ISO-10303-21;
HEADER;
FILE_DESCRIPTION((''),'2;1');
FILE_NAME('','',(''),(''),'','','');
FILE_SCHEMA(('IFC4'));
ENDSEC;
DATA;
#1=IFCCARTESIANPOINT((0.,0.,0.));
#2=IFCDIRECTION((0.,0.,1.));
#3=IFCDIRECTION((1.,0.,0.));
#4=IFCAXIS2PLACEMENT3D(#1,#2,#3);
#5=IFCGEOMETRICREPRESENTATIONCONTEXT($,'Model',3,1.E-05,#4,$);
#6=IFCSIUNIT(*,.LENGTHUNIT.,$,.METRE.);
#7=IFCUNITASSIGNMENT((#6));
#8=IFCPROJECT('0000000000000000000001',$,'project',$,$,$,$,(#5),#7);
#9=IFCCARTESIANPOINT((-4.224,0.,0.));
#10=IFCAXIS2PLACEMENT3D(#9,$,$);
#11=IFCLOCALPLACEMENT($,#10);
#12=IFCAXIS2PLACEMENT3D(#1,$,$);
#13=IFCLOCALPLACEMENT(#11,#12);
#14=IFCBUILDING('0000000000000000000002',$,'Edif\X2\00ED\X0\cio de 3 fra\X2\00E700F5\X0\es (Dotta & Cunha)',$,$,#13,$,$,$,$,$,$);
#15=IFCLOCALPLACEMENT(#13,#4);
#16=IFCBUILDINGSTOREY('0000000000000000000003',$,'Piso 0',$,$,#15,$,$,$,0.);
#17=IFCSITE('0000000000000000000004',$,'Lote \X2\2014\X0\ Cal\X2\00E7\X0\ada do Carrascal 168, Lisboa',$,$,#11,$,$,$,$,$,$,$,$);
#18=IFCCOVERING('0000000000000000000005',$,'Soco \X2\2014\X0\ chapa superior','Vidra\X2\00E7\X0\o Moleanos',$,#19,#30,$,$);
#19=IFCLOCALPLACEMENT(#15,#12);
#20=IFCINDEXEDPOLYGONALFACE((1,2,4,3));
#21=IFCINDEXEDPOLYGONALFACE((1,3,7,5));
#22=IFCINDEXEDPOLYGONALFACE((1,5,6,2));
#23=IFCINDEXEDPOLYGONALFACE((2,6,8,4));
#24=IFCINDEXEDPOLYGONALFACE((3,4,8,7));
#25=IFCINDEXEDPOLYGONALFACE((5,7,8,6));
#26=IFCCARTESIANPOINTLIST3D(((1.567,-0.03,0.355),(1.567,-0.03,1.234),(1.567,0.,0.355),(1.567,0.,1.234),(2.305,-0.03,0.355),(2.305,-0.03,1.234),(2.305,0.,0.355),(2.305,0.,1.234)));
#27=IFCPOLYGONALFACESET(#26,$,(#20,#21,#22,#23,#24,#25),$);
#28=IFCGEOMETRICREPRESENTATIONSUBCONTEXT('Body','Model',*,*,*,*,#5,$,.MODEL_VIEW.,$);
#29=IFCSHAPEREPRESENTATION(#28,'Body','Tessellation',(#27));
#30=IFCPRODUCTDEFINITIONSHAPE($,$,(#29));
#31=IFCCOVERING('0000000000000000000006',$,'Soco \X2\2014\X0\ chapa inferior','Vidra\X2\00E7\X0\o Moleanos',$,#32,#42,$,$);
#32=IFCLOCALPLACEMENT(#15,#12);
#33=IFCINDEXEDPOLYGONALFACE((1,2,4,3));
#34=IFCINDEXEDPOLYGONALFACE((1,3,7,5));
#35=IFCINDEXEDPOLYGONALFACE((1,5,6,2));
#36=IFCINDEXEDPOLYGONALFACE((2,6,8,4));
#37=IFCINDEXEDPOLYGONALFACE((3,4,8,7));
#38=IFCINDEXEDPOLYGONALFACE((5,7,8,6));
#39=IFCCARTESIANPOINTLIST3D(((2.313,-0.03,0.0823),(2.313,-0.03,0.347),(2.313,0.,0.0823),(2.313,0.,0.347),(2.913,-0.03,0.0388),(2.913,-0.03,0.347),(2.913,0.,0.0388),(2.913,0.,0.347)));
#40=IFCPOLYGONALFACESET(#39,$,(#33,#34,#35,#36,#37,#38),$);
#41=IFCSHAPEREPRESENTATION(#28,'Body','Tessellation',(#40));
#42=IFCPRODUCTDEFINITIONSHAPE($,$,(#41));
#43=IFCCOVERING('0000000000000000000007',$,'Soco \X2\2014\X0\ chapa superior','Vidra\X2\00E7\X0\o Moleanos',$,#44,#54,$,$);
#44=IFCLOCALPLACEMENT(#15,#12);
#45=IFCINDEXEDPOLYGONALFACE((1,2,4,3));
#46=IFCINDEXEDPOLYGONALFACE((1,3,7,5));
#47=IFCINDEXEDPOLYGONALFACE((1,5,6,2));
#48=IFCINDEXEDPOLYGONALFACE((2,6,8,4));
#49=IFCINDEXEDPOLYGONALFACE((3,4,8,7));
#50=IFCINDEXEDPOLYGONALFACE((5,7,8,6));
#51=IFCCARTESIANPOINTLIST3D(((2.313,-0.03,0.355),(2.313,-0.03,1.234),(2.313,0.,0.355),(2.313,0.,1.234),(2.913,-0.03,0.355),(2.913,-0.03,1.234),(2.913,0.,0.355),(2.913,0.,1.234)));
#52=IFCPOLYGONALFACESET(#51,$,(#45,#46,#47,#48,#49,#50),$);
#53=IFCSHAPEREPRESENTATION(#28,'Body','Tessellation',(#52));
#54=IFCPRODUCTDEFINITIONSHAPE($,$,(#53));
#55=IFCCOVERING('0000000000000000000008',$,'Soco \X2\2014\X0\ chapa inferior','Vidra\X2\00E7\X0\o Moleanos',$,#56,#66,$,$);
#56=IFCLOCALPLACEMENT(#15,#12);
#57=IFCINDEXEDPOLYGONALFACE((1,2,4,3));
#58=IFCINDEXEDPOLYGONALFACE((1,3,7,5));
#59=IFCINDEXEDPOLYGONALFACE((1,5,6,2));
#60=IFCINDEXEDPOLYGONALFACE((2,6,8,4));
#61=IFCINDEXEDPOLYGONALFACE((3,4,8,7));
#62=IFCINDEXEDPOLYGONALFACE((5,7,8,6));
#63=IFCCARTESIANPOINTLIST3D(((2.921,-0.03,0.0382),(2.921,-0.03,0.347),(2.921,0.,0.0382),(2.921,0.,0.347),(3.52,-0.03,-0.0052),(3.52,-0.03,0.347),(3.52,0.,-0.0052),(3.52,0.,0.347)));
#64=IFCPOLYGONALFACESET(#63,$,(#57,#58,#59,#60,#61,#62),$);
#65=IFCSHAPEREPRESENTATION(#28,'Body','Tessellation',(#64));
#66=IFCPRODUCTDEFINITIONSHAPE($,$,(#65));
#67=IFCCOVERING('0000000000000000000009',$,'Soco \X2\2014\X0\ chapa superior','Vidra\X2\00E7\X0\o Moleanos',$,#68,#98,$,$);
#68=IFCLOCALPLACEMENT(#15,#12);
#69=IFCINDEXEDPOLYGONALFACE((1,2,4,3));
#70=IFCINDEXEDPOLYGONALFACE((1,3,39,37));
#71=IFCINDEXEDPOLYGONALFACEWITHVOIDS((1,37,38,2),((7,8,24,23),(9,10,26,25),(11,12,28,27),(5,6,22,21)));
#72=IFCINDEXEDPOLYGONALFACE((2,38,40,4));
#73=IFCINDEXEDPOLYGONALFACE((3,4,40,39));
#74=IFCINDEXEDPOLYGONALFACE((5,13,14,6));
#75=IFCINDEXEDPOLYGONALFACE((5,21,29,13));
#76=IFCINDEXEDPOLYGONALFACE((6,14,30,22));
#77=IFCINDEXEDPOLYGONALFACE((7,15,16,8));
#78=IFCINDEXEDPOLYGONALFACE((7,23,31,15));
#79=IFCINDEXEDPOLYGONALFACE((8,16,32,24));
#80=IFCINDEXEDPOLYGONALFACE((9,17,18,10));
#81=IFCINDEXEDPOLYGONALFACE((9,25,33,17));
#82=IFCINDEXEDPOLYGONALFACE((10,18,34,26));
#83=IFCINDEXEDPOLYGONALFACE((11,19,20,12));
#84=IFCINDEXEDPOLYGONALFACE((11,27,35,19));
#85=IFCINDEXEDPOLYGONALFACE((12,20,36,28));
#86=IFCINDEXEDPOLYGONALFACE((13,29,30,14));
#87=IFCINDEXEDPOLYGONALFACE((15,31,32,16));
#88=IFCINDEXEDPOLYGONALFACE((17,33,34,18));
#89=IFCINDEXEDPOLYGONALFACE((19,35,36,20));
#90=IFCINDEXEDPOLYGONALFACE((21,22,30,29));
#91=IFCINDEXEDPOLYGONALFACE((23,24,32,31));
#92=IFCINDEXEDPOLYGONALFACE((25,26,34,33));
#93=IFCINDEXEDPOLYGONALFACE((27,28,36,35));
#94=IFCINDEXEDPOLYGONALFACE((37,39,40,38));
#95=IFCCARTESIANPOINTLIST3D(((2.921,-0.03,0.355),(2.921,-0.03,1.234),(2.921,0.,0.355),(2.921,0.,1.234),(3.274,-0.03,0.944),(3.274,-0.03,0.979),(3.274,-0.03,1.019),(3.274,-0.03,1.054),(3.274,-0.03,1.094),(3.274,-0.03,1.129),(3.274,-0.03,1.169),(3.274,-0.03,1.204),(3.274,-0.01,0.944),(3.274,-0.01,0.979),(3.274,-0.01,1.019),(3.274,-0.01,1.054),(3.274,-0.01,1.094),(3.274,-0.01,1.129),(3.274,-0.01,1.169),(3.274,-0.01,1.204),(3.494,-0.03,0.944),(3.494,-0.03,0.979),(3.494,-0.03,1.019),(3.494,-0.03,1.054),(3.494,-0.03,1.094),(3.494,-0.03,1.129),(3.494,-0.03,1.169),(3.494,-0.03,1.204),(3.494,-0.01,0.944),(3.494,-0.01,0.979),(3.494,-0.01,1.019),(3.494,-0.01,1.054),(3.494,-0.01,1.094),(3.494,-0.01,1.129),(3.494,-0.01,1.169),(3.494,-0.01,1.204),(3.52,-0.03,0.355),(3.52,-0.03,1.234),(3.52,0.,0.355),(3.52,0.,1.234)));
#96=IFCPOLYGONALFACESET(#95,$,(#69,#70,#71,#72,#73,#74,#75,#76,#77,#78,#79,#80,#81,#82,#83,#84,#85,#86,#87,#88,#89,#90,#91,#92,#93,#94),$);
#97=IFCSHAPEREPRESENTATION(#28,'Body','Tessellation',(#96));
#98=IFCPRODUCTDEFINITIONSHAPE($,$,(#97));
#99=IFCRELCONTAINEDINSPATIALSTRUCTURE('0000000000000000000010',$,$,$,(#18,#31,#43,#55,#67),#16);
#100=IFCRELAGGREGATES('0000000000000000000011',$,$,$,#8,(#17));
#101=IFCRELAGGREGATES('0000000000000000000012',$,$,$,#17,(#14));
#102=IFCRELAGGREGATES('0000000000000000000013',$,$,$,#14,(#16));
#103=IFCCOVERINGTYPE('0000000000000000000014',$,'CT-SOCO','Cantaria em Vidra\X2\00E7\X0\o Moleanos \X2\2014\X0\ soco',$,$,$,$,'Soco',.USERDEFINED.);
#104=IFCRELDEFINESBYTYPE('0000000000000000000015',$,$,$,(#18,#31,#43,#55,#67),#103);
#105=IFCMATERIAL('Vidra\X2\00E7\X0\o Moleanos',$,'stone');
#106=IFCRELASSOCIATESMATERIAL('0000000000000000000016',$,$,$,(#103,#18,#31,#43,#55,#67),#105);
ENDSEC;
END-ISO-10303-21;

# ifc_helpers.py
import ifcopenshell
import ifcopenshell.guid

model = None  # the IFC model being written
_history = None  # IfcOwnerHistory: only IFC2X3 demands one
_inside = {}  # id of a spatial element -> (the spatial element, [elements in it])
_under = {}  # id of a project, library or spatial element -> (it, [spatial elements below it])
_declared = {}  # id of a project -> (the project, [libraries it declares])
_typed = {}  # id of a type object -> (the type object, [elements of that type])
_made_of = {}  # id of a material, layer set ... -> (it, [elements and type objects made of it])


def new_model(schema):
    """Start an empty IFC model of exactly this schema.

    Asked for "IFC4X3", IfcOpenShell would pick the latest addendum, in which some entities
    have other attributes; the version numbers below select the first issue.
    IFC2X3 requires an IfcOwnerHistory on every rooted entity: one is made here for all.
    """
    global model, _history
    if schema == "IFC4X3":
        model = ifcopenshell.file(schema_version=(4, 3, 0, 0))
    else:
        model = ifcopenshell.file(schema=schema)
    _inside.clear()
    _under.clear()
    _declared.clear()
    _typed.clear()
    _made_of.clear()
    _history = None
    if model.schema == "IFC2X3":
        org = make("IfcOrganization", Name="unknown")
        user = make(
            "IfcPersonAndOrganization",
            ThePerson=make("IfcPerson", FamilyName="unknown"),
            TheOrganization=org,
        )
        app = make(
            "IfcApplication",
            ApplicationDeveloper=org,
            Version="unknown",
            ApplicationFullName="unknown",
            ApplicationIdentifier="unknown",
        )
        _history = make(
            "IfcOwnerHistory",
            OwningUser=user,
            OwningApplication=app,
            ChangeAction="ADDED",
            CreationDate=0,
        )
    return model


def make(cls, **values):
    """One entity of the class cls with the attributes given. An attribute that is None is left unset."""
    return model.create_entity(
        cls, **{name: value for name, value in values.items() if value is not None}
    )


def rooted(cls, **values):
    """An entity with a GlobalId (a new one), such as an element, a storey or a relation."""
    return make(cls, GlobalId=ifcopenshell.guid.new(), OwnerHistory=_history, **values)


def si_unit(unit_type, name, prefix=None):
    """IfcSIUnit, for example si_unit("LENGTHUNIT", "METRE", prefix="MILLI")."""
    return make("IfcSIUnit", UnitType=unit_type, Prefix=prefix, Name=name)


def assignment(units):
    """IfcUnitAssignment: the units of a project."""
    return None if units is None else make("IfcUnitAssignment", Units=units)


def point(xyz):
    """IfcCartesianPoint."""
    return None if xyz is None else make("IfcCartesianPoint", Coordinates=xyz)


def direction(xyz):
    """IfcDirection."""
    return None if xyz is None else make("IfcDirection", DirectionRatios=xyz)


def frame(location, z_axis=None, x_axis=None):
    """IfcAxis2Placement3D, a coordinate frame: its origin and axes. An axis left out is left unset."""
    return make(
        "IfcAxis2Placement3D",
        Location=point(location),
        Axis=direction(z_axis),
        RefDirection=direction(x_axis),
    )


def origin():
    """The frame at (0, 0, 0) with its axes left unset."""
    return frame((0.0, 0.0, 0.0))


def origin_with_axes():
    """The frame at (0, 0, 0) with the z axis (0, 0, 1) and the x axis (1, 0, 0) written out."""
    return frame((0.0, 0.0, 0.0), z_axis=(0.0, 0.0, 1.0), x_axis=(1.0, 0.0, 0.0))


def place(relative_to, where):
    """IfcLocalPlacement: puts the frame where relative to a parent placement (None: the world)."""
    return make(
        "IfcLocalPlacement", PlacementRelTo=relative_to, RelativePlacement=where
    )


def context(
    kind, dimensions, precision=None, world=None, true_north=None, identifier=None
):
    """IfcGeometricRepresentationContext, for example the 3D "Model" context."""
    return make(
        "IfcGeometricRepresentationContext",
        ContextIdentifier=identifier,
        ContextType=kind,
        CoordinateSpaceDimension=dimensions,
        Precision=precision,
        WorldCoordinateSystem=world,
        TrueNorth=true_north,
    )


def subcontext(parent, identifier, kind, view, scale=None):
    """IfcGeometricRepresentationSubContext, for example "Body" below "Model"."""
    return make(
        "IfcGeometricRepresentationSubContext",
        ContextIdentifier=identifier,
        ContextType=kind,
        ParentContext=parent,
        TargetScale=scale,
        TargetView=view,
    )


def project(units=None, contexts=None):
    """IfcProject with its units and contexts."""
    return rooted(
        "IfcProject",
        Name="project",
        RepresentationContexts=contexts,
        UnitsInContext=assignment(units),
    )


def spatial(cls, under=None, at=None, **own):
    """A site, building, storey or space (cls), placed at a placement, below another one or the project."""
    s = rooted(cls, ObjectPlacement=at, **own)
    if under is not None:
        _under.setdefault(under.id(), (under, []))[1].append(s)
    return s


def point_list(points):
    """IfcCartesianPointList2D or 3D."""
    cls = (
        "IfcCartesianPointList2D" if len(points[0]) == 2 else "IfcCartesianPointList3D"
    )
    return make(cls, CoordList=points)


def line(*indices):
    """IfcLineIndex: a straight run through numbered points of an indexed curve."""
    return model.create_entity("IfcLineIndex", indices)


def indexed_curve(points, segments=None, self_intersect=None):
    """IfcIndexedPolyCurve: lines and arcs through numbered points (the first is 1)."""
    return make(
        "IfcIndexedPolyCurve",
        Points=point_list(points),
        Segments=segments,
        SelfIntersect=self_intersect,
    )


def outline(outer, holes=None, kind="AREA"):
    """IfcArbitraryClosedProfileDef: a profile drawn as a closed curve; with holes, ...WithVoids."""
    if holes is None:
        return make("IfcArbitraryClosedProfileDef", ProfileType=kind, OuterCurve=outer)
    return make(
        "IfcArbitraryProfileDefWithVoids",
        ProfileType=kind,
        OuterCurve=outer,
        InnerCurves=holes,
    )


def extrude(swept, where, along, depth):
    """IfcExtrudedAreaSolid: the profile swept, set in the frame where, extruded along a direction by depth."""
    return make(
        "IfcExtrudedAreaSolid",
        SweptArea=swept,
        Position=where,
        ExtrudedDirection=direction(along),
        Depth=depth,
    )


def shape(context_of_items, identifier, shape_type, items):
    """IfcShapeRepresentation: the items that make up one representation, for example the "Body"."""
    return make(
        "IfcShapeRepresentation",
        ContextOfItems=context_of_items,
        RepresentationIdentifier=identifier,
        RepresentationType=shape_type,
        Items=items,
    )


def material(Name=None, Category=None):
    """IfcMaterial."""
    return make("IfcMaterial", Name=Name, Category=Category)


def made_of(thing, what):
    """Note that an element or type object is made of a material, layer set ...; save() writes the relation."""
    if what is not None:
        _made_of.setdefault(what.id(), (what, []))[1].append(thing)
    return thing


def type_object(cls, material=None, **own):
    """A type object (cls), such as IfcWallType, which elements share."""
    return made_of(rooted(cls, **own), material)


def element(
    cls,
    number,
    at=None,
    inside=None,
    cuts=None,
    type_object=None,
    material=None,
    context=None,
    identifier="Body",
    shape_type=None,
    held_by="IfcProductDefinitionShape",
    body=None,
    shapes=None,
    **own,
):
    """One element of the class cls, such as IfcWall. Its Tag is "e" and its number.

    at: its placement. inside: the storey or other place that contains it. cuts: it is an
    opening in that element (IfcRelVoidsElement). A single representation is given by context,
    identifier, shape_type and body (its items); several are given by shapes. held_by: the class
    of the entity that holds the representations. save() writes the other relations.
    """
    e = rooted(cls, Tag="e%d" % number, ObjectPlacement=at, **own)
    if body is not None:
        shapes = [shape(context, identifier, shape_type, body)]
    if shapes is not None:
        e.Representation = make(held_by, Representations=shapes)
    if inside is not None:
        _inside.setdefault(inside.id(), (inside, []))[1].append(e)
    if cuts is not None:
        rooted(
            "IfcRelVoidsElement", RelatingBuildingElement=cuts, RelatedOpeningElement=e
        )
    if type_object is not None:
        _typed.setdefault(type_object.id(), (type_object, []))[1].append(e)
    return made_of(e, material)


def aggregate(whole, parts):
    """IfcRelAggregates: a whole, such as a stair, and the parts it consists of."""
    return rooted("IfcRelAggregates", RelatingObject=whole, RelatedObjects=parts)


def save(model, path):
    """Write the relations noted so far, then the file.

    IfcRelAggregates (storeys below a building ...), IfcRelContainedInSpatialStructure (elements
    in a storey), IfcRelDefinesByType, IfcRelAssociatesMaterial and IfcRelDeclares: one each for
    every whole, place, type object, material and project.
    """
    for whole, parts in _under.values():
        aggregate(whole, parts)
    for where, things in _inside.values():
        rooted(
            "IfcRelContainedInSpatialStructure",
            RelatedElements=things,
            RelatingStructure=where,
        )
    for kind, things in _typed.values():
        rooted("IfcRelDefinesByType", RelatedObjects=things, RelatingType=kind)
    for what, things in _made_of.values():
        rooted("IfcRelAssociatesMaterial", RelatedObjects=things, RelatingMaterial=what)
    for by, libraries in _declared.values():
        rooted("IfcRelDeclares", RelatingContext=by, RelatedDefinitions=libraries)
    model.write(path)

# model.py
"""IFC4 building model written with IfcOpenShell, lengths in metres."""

from ifc_helpers import new_model, si_unit, frame, origin, origin_with_axes, place, context, subcontext, project, spatial, line, indexed_curve, outline, extrude, material, type_object, element, save


model = new_model("IFC4")

# Units and contexts
model_context = context("Model", 3, precision=1e-05, world=origin_with_axes())
body_context = subcontext(model_context, "Body", "Model", "MODEL_VIEW")
ifc_project = project(units=[si_unit("LENGTHUNIT", "METRE")], contexts=[model_context])

# Site, building, storey
site_placement = place(None, frame((-4.224, 0.0, 0.0)))
site = spatial("IfcSite", under=ifc_project, at=site_placement, Name="Lote — Calçada do Carrascal 168, Lisboa")
building_placement = place(site_placement, origin())
building = spatial("IfcBuilding", under=site, at=building_placement, Name="Edifício de 3 frações (Dotta & Cunha)")
storey_placement = place(building_placement, origin_with_axes())
storey = spatial("IfcBuildingStorey", under=building, at=storey_placement, Name="Piso 0", Elevation=0.0)

# Coverings
ifc_material_1 = material(Name="Vidraço Moleanos", Category="stone")
covering_type_1 = type_object("IfcCoveringType", Name="CT-SOCO", Description="Cantaria em Vidraço Moleanos — soco", ElementType="Soco", PredefinedType="USERDEFINED", material=ifc_material_1)
covering_1_placement = place(storey_placement, frame((0.0, 0.0, 0.0), z_axis=(0.0, -1.0, 0.0), x_axis=(1.0, 0.0, 0.0)))
element("IfcCovering", 1, at=covering_1_placement, inside=storey, type_object=covering_type_1, material=ifc_material_1, Name="Soco — chapa superior", Description="Vidraço Moleanos", context=body_context, shape_type="SweptSolid", body=[
    extrude(outline(indexed_curve([(2.305, 0.355), (2.305, 1.234), (1.567, 1.234), (1.567, 0.355)], segments=[line(1, 2, 3, 4, 1)])), origin_with_axes(), (0.0, 0.0, 1.0), 0.03),
])
covering_2_placement = place(storey_placement, frame((0.0, 0.0, 0.0), z_axis=(0.0, -1.0, 0.0), x_axis=(1.0, 0.0, 0.0)))
element("IfcCovering", 2, at=covering_2_placement, inside=storey, type_object=covering_type_1, material=ifc_material_1, Name="Soco — chapa inferior", Description="Vidraço Moleanos", context=body_context, shape_type="SweptSolid", body=[
    extrude(outline(indexed_curve([(2.313, 0.0823), (2.913, 0.0388), (2.913, 0.347), (2.313, 0.347)], segments=[line(1, 2, 3, 4, 1)])), origin_with_axes(), (0.0, 0.0, 1.0), 0.03),
])
covering_3_placement = place(storey_placement, frame((0.0, 0.0, 0.0), z_axis=(0.0, -1.0, 0.0), x_axis=(1.0, 0.0, 0.0)))
element("IfcCovering", 3, at=covering_3_placement, inside=storey, type_object=covering_type_1, material=ifc_material_1, Name="Soco — chapa superior", Description="Vidraço Moleanos", context=body_context, shape_type="SweptSolid", body=[
    extrude(outline(indexed_curve([(2.913, 0.355), (2.913, 1.234), (2.313, 1.234), (2.313, 0.355)], segments=[line(1, 2, 3, 4, 1)])), origin_with_axes(), (0.0, 0.0, 1.0), 0.03),
])
covering_4_placement = place(storey_placement, frame((0.0, 0.0, 0.0), z_axis=(0.0, -1.0, 0.0), x_axis=(1.0, 0.0, 0.0)))
element("IfcCovering", 4, at=covering_4_placement, inside=storey, type_object=covering_type_1, material=ifc_material_1, Name="Soco — chapa inferior", Description="Vidraço Moleanos", context=body_context, shape_type="SweptSolid", body=[
    extrude(outline(indexed_curve([(2.921, 0.0382), (3.52, -0.0052), (3.52, 0.347), (2.921, 0.347)], segments=[line(1, 2, 3, 4, 1)])), origin_with_axes(), (0.0, 0.0, 1.0), 0.03),
])

# Covering, openings
covering_5_placement = place(storey_placement, frame((0.0, 0.0, 0.0), z_axis=(0.0, -1.0, 0.0), x_axis=(1.0, 0.0, 0.0)))
covering_5 = element("IfcCovering", 5, at=covering_5_placement, inside=storey, type_object=covering_type_1, material=ifc_material_1, Name="Soco — chapa superior", Description="Vidraço Moleanos", context=body_context, shape_type="SweptSolid", body=[
    extrude(outline(indexed_curve([(3.52, 0.355), (3.52, 1.234), (2.921, 1.234), (2.921, 0.355)], segments=[line(1, 2, 3, 4, 1)])), origin_with_axes(), (0.0, 0.0, 1.0), 0.03),
])
opening_1_placement = place(covering_5_placement, frame((0.0, 0.0, 0.01), z_axis=(0.0, 0.0, 1.0), x_axis=(1.0, 0.0, 0.0)))
element("IfcOpeningElement", 6, at=opening_1_placement, cuts=covering_5, PredefinedType="RECESS", context=body_context, shape_type="SweptSolid", body=[
    extrude(outline(indexed_curve([(3.494, 0.944), (3.494, 0.979), (3.274, 0.979), (3.274, 0.944)], segments=[line(1, 2, 3, 4, 1)])), origin_with_axes(), (0.0, 0.0, 1.0), 0.03),
])
opening_2_placement = place(covering_5_placement, frame((0.0, 0.0, 0.01), z_axis=(0.0, 0.0, 1.0), x_axis=(1.0, 0.0, 0.0)))
element("IfcOpeningElement", 7, at=opening_2_placement, cuts=covering_5, PredefinedType="RECESS", context=body_context, shape_type="SweptSolid", body=[
    extrude(outline(indexed_curve([(3.494, 1.019), (3.494, 1.054), (3.274, 1.054), (3.274, 1.019)], segments=[line(1, 2, 3, 4, 1)])), origin_with_axes(), (0.0, 0.0, 1.0), 0.03),
])
opening_3_placement = place(covering_5_placement, frame((0.0, 0.0, 0.01), z_axis=(0.0, 0.0, 1.0), x_axis=(1.0, 0.0, 0.0)))
element("IfcOpeningElement", 8, at=opening_3_placement, cuts=covering_5, PredefinedType="RECESS", context=body_context, shape_type="SweptSolid", body=[
    extrude(outline(indexed_curve([(3.494, 1.094), (3.494, 1.129), (3.274, 1.129), (3.274, 1.094)], segments=[line(1, 2, 3, 4, 1)])), origin_with_axes(), (0.0, 0.0, 1.0), 0.03),
])
opening_4_placement = place(covering_5_placement, frame((0.0, 0.0, 0.01), z_axis=(0.0, 0.0, 1.0), x_axis=(1.0, 0.0, 0.0)))
element("IfcOpeningElement", 9, at=opening_4_placement, cuts=covering_5, PredefinedType="RECESS", context=body_context, shape_type="SweptSolid", body=[
    extrude(outline(indexed_curve([(3.494, 1.169), (3.494, 1.204), (3.274, 1.204), (3.274, 1.169)], segments=[line(1, 2, 3, 4, 1)])), origin_with_axes(), (0.0, 0.0, 1.0), 0.03),
])

save(model, "model.ifc")
